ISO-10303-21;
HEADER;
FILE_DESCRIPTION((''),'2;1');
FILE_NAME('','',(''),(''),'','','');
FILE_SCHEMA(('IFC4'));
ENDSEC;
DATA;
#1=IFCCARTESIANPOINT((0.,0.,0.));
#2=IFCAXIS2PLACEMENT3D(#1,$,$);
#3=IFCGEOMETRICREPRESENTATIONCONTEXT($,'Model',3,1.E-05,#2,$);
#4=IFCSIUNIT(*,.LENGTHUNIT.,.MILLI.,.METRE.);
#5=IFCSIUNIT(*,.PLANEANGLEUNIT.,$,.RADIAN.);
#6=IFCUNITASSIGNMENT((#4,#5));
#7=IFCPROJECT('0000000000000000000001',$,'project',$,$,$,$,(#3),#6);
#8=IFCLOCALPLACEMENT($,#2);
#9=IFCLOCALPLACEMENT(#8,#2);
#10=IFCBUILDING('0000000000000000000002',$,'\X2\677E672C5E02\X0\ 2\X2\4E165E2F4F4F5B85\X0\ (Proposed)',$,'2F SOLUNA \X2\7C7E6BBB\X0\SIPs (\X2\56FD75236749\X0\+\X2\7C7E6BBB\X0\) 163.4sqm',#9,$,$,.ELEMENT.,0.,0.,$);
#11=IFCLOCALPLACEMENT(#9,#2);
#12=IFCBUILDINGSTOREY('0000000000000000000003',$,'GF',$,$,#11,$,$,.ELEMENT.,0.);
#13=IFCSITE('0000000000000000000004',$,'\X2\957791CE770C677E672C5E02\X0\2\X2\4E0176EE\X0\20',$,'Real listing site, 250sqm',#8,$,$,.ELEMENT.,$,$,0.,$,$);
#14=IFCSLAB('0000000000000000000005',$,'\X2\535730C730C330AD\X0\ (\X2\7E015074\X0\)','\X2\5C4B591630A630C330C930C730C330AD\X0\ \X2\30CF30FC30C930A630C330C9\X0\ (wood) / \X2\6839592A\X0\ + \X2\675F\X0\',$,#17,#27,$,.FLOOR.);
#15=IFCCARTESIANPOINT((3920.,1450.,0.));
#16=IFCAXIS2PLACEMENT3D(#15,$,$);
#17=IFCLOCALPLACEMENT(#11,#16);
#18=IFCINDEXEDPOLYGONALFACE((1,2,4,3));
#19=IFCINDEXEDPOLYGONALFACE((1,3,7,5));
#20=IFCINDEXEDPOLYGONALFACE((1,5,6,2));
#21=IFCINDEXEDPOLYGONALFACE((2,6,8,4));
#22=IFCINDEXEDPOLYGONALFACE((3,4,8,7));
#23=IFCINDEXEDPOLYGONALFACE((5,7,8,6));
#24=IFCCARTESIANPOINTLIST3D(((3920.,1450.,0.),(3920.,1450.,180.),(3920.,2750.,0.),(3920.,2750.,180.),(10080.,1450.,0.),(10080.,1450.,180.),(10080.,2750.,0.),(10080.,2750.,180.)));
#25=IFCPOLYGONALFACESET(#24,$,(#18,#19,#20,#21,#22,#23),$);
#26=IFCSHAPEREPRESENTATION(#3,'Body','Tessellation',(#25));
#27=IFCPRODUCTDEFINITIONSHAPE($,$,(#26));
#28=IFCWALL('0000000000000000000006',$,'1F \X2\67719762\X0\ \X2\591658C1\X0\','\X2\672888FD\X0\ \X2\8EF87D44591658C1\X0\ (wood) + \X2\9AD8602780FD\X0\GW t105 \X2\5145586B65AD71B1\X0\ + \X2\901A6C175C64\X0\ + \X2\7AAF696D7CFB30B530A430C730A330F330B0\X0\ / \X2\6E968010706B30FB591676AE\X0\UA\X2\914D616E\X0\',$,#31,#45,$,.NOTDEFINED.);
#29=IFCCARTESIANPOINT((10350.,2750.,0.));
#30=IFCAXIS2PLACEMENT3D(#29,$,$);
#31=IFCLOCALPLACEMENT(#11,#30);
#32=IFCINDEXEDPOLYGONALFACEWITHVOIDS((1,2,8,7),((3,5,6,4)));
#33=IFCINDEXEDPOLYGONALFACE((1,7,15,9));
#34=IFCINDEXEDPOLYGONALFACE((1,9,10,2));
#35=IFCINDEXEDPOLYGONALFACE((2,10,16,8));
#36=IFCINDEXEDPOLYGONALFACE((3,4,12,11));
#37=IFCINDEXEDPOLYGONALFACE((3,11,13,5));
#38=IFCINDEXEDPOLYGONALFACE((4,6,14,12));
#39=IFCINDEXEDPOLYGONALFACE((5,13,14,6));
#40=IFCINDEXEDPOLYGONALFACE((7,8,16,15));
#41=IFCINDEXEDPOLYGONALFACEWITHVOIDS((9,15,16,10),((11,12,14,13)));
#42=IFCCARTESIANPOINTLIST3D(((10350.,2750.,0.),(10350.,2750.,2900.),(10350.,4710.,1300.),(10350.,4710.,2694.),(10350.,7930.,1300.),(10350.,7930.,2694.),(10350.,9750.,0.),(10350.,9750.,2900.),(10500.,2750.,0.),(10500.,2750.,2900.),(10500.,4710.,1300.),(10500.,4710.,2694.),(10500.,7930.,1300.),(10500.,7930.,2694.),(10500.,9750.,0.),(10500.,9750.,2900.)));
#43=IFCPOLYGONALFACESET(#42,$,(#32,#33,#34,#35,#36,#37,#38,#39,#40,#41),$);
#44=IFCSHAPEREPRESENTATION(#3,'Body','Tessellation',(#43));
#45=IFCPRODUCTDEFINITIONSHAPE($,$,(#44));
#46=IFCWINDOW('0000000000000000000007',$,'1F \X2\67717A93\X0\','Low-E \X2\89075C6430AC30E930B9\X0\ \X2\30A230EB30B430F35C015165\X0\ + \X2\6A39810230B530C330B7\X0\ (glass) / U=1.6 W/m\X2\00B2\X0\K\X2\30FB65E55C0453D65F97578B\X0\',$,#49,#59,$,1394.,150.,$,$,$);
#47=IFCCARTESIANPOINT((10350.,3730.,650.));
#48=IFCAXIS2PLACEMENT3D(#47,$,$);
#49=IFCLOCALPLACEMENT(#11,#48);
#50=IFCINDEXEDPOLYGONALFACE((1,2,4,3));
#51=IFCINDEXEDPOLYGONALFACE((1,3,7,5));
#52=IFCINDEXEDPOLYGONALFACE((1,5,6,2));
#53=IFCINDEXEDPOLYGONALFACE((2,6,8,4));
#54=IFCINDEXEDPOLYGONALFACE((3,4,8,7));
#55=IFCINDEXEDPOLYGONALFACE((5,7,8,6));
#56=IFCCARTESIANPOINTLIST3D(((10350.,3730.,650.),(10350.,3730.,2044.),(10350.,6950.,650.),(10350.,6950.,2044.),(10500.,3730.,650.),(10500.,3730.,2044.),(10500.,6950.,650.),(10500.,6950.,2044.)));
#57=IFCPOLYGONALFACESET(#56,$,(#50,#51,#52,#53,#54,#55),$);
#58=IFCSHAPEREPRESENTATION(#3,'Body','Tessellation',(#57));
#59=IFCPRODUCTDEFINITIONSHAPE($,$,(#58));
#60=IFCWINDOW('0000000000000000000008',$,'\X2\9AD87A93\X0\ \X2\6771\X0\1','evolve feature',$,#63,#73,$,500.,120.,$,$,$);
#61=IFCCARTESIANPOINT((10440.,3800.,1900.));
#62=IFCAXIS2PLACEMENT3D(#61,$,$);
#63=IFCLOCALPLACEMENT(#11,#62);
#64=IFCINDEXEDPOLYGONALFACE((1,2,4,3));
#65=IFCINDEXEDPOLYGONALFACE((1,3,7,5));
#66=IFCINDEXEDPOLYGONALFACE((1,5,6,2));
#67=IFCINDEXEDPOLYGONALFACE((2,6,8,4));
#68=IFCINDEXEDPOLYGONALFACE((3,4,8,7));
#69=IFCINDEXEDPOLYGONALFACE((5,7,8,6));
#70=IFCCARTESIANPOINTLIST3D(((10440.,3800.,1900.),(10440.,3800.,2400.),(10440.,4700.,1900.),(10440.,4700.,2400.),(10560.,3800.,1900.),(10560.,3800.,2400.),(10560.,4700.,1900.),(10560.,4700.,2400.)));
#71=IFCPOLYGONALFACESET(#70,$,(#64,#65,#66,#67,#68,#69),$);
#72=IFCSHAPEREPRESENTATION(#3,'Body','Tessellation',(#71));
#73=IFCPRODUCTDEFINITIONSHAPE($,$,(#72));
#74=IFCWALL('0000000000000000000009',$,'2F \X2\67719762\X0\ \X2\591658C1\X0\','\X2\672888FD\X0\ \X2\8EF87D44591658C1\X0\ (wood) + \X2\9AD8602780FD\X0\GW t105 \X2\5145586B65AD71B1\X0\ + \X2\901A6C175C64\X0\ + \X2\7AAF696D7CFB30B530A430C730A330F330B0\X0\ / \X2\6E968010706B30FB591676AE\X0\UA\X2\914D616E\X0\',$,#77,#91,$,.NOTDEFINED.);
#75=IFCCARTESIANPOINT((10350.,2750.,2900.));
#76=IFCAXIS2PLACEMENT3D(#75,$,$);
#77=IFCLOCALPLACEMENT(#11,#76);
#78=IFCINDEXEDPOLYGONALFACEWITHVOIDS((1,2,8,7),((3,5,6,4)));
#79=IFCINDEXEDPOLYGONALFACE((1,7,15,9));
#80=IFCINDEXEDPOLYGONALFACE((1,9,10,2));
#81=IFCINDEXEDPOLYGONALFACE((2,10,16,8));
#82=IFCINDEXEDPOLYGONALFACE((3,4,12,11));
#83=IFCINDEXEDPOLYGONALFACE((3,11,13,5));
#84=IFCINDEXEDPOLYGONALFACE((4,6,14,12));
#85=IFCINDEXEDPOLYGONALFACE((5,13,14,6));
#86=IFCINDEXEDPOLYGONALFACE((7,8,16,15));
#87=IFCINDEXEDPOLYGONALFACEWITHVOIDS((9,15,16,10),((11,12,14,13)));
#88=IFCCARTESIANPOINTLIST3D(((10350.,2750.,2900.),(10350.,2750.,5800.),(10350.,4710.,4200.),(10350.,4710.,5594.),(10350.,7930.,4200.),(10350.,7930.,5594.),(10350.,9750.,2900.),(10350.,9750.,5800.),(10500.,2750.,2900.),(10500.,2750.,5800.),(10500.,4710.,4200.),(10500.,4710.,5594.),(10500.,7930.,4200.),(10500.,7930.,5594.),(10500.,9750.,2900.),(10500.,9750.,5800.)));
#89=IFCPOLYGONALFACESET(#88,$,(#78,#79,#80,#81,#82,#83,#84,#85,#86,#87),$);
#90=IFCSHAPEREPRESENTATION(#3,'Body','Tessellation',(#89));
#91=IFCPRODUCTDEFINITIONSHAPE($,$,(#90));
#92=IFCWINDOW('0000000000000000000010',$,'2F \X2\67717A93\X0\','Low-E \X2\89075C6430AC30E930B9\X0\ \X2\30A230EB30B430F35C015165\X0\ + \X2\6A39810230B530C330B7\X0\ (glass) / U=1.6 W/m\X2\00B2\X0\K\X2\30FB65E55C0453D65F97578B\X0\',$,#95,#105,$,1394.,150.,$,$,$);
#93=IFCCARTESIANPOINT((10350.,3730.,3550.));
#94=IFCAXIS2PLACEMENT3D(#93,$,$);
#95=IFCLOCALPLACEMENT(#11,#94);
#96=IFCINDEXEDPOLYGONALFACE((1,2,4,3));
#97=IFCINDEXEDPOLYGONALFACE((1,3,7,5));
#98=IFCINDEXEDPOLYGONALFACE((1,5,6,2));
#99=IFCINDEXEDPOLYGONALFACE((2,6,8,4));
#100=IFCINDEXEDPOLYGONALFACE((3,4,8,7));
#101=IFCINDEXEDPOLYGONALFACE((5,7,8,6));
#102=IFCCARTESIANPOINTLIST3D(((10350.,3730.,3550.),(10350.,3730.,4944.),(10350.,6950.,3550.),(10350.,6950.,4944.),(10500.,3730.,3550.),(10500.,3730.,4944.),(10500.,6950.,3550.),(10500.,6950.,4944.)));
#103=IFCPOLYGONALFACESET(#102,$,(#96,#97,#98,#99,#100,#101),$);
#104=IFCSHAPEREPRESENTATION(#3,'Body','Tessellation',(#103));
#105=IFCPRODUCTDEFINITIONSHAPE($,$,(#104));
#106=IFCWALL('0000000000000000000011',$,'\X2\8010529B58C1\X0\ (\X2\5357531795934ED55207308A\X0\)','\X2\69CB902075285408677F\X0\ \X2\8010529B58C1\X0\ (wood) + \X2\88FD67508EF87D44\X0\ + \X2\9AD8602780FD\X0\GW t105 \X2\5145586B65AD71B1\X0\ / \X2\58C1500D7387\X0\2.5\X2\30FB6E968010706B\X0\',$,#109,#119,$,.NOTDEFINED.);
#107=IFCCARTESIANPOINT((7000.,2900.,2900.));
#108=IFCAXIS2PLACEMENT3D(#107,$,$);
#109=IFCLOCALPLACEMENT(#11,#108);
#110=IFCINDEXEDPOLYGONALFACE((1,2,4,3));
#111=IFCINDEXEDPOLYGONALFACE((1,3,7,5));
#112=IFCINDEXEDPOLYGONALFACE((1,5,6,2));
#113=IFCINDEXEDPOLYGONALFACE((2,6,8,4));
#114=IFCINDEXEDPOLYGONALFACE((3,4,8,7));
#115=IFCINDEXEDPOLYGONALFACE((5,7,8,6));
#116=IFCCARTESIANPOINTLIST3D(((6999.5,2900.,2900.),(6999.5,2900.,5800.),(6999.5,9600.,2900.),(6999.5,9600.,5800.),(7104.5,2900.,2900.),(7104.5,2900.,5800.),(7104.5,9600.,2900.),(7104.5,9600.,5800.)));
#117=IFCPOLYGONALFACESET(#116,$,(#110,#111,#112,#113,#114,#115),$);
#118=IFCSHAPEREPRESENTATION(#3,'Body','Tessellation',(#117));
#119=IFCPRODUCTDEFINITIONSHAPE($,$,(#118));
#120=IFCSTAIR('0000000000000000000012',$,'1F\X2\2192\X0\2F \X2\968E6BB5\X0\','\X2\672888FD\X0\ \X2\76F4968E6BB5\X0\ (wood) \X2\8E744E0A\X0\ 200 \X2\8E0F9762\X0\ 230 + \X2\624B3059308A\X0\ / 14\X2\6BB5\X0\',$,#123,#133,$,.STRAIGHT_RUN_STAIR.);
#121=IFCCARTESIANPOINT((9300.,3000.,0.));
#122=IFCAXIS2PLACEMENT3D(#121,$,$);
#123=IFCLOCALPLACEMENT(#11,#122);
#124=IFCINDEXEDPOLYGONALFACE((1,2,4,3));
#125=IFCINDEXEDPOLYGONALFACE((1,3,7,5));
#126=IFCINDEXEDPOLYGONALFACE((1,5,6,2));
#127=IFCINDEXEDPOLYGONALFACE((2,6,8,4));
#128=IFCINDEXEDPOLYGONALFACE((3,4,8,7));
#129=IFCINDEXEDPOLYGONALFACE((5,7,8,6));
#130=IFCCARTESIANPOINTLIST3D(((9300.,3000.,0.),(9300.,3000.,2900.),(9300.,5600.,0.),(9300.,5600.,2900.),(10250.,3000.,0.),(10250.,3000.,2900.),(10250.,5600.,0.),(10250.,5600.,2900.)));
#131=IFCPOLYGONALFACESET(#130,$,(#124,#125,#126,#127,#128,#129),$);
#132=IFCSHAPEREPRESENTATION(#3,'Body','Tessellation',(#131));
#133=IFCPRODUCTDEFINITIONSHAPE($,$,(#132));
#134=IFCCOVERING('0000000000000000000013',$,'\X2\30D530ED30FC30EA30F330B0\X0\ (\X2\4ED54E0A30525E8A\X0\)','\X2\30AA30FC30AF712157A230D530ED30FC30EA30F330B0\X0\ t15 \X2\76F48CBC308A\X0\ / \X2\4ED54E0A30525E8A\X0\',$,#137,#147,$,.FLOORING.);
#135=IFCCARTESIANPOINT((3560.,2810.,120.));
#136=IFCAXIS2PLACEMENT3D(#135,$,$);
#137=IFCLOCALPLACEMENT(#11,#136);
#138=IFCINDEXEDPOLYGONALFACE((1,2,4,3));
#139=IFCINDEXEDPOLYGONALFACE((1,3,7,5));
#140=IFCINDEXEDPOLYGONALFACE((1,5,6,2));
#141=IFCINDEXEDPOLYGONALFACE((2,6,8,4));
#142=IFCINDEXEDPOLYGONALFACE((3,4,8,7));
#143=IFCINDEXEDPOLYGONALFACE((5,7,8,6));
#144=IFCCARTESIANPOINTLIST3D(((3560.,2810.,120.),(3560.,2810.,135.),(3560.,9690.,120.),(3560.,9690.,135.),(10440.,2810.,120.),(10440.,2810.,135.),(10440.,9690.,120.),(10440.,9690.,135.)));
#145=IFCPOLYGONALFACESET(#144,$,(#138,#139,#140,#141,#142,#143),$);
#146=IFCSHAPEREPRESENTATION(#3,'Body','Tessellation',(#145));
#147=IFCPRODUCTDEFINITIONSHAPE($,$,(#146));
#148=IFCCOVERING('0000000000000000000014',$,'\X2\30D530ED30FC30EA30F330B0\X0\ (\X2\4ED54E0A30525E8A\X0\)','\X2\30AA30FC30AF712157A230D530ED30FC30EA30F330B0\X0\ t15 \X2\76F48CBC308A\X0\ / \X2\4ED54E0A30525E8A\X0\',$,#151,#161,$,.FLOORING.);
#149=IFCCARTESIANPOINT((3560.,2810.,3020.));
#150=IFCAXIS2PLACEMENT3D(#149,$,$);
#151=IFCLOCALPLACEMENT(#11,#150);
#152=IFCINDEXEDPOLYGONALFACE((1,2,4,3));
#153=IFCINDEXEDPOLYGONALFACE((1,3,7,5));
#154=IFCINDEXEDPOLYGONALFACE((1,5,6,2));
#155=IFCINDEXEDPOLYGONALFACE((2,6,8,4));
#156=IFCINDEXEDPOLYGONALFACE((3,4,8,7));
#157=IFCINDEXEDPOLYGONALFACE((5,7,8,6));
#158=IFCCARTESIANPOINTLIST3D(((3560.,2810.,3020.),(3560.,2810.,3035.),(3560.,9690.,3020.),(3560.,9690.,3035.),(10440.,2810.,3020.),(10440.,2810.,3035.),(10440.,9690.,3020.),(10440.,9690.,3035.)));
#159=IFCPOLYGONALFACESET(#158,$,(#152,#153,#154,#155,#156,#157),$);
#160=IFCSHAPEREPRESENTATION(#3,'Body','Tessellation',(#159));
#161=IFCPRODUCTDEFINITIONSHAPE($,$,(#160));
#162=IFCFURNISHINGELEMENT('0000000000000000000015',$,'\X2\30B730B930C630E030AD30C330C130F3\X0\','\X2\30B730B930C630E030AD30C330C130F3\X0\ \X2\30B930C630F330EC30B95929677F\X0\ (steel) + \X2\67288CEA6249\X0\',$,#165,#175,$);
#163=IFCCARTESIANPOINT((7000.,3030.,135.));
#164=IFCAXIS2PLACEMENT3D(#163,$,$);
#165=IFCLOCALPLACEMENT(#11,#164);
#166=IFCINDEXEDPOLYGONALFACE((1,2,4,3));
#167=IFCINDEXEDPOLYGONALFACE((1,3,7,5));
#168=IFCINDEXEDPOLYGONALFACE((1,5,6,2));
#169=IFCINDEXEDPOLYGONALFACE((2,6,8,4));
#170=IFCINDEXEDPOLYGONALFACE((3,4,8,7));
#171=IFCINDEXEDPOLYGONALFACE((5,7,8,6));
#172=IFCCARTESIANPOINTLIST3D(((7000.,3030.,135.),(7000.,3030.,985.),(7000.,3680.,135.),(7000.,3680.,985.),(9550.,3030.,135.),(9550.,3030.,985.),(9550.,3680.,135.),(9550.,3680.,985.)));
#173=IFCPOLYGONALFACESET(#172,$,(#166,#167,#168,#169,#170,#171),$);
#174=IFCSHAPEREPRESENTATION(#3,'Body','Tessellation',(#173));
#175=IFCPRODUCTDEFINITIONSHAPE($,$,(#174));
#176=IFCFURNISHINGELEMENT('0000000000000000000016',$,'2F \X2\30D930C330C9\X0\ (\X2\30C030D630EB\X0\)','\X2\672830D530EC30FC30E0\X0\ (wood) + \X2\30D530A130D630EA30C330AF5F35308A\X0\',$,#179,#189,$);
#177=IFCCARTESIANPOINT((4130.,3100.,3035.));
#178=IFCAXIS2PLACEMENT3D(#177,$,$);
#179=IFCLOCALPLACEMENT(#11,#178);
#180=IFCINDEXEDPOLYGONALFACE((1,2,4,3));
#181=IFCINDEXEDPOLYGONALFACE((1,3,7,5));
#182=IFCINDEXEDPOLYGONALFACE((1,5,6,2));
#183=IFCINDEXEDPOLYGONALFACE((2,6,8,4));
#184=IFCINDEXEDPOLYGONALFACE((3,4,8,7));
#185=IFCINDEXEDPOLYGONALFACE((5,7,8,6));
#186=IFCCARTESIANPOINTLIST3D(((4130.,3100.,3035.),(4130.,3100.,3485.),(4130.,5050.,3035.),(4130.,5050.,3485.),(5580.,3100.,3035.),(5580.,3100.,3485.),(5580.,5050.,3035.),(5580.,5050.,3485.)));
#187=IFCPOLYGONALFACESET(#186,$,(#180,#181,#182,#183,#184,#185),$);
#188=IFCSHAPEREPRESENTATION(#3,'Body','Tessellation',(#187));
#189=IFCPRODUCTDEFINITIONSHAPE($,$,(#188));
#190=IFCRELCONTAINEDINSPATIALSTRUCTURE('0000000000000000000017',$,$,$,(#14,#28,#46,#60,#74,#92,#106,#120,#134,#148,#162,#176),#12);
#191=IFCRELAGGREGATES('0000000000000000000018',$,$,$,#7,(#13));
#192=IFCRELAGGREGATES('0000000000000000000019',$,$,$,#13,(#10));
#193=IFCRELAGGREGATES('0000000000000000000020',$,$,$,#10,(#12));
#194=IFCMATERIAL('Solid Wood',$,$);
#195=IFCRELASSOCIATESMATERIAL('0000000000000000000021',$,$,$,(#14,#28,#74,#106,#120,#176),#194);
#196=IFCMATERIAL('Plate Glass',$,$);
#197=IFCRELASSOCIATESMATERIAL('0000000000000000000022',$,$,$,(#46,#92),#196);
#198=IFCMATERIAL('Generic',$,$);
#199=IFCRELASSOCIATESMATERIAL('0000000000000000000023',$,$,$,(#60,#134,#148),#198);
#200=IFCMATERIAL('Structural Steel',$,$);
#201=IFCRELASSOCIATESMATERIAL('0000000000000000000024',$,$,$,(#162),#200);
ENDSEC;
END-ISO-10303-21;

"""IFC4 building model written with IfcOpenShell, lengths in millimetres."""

from ifc_helpers import new_model, si_unit, frame, frame_2d, origin, place, context, project, spatial, rectangle, extrude, material, element, fill, save


model = new_model("IFC4")

# Units and contexts
model_context = context("Model", 3, precision=1e-05, world=origin())
ifc_project = project(units=[si_unit("LENGTHUNIT", "METRE", prefix="MILLI"), si_unit("PLANEANGLEUNIT", "RADIAN")], contexts=[model_context])

# Site, building, storey
site_placement = place(None, origin())
site = spatial("IfcSite", under=ifc_project, at=site_placement, Name="長野県松本市2丁目20", ObjectType="Real listing site, 250sqm", CompositionType="ELEMENT", RefElevation=0.0)
building_placement = place(site_placement, origin())
building = spatial("IfcBuilding", under=site, at=building_placement, Name="松本市 2世帯住宅 (Proposed)", ObjectType="2F SOLUNA 籾殻SIPs (国産杉+籾殻) 163.4sqm", CompositionType="ELEMENT", ElevationOfRefHeight=0.0, ElevationOfTerrain=0.0)
storey_placement = place(building_placement, origin())
storey = spatial("IfcBuildingStorey", under=building, at=storey_placement, Name="GF", CompositionType="ELEMENT", Elevation=0.0)

# Slab
ifc_material_1 = material(Name="Solid Wood")
slab_placement = place(storey_placement, frame((3920.0, 1450.0, 0.0)))
element("IfcSlab", 1, at=slab_placement, inside=storey, material=ifc_material_1, Name="南デッキ (縁側)", Description="屋外ウッドデッキ ハードウッド (wood) / 根太 + 束", PredefinedType="FLOOR", context=model_context, shape_type="SweptSolid", body=[
    extrude(rectangle(XDim=6160.0, YDim=1300.0, at=frame_2d((3080.0, 650.0))), frame((3920.0, 1450.0, 0.0)), (0.0, 0.0, 1.0), 180.0),
])

# Wall, openings, windows
wall_1_placement = place(storey_placement, frame((10350.0, 2750.0, 0.0)))
wall_1 = element("IfcWall", 2, at=wall_1_placement, inside=storey, material=ifc_material_1, Name="1F 東面 外壁", Description="木製 軸組外壁 (wood) + 高性能GW t105 充填断熱 + 通気層 + 窯業系サイディング / 準耐火・外皮UA配慮", PredefinedType="NOTDEFINED", context=model_context, shape_type="SweptSolid", body=[
    extrude(rectangle(XDim=150.0, YDim=7000.0, at=frame_2d((75.0, 3500.0))), frame((10350.0, 2750.0, 0.0)), (0.0, 0.0, 1.0), 2900.0),
])
opening_1_placement = place(storey_placement, frame((10350.0, 3730.0, 650.0)))
opening_1 = element("IfcOpeningElement", 3, at=opening_1_placement, cuts=wall_1, PredefinedType="NOTDEFINED", context=model_context, shape_type="SweptSolid", body=[
    extrude(rectangle(XDim=150.0, YDim=3220.0, at=frame_2d((75.0, 1610.0))), frame((10350.0, 3730.0, 650.0)), (0.0, 0.0, 1.0), 1394.0),
])
opening_2_placement = place(storey_placement, frame((10440.0, 3800.0, 1900.0)))
opening_2 = element("IfcOpeningElement", 4, at=opening_2_placement, cuts=wall_1, PredefinedType="NOTDEFINED", context=model_context, shape_type="SweptSolid", body=[
    extrude(rectangle(XDim=120.0, YDim=900.0, at=frame_2d((60.0, 450.0))), frame((10440.0, 3800.0, 1900.0)), (0.0, 0.0, 1.0), 500.0),
])
ifc_material_2 = material(Name="Plate Glass")
window_1_placement = place(storey_placement, frame((10350.0, 3730.0, 650.0)))
window_1 = element("IfcWindow", 5, at=window_1_placement, inside=storey, material=ifc_material_2, Name="1F 東窓", Description="Low-E 複層ガラス アルゴン封入 + 樹脂サッシ (glass) / U=1.6 W/m²K・日射取得型", OverallHeight=1394.0, OverallWidth=150.0, context=model_context, shape_type="SweptSolid", body=[
    extrude(rectangle(XDim=150.0, YDim=3220.0, at=frame_2d((75.0, 1610.0))), frame((10350.0, 3730.0, 650.0)), (0.0, 0.0, 1.0), 1394.0),
])
fill(opening_1, window_1)
ifc_material_3 = material(Name="Generic")
window_2_placement = place(storey_placement, frame((10440.0, 3800.0, 1900.0)))
window_2 = element("IfcWindow", 6, at=window_2_placement, inside=storey, material=ifc_material_3, Name="高窓 東1", Description="evolve feature", OverallHeight=500.0, OverallWidth=120.0, context=model_context, shape_type="SweptSolid", body=[
    extrude(rectangle(XDim=120.0, YDim=900.0, at=frame_2d((60.0, 450.0))), frame((10440.0, 3800.0, 1900.0)), (0.0, 0.0, 1.0), 500.0),
])
fill(opening_2, window_2)

# Wall, opening, window
wall_2_placement = place(storey_placement, frame((10350.0, 2750.0, 2900.0)))
wall_2 = element("IfcWall", 7, at=wall_2_placement, inside=storey, material=ifc_material_1, Name="2F 東面 外壁", Description="木製 軸組外壁 (wood) + 高性能GW t105 充填断熱 + 通気層 + 窯業系サイディング / 準耐火・外皮UA配慮", PredefinedType="NOTDEFINED", context=model_context, shape_type="SweptSolid", body=[
    extrude(rectangle(XDim=150.0, YDim=7000.0, at=frame_2d((75.0, 3500.0))), frame((10350.0, 2750.0, 2900.0)), (0.0, 0.0, 1.0), 2900.0),
])
opening_3_placement = place(storey_placement, frame((10350.0, 3730.0, 3550.0)))
opening_3 = element("IfcOpeningElement", 8, at=opening_3_placement, cuts=wall_2, PredefinedType="NOTDEFINED", context=model_context, shape_type="SweptSolid", body=[
    extrude(rectangle(XDim=150.0, YDim=3220.0, at=frame_2d((75.0, 1610.0))), frame((10350.0, 3730.0, 3550.0)), (0.0, 0.0, 1.0), 1394.0),
])
window_3_placement = place(storey_placement, frame((10350.0, 3730.0, 3550.0)))
window_3 = element("IfcWindow", 9, at=window_3_placement, inside=storey, material=ifc_material_2, Name="2F 東窓", Description="Low-E 複層ガラス アルゴン封入 + 樹脂サッシ (glass) / U=1.6 W/m²K・日射取得型", OverallHeight=1394.0, OverallWidth=150.0, context=model_context, shape_type="SweptSolid", body=[
    extrude(rectangle(XDim=150.0, YDim=3220.0, at=frame_2d((75.0, 1610.0))), frame((10350.0, 3730.0, 3550.0)), (0.0, 0.0, 1.0), 1394.0),
])
fill(opening_3, window_3)

# Wall
wall_3_placement = place(storey_placement, frame((7000.0, 2900.0, 2900.0)))
element("IfcWall", 10, at=wall_3_placement, inside=storey, material=ifc_material_1, Name="耐力壁 (南北間仕切り)", Description="構造用合板 耐力壁 (wood) + 製材軸組 + 高性能GW t105 充填断熱 / 壁倍率2.5・準耐火", PredefinedType="NOTDEFINED", context=model_context, shape_type="SweptSolid", body=[
    extrude(rectangle(XDim=105.0, YDim=6700.0, at=frame_2d((52.0, 3350.0))), frame((7000.0, 2900.0, 2900.0)), (0.0, 0.0, 1.0), 2900.0),
])

# Stair
stair_placement = place(storey_placement, frame((9300.0, 3000.0, 0.0)))
element("IfcStair", 11, at=stair_placement, inside=storey, material=ifc_material_1, Name="1F→2F 階段", Description="木製 直階段 (wood) 蹴上 200 踏面 230 + 手すり / 14段", PredefinedType="STRAIGHT_RUN_STAIR", context=model_context, shape_type="SweptSolid", body=[
    extrude(rectangle(XDim=950.0, YDim=2600.0, at=frame_2d((475.0, 1300.0))), frame((9300.0, 3000.0, 0.0)), (0.0, 0.0, 1.0), 2900.0),
])

# Coverings
covering_1_placement = place(storey_placement, frame((3560.0, 2810.0, 120.0)))
element("IfcCovering", 12, at=covering_1_placement, inside=storey, material=ifc_material_3, Name="フローリング (仕上げ床)", Description="オーク無垢フローリング t15 直貼り / 仕上げ床", PredefinedType="FLOORING", context=model_context, shape_type="SweptSolid", body=[
    extrude(rectangle(XDim=6880.0, YDim=6880.0, at=frame_2d((3440.0, 3440.0))), frame((3560.0, 2810.0, 120.0)), (0.0, 0.0, 1.0), 15.0),
])
covering_2_placement = place(storey_placement, frame((3560.0, 2810.0, 3020.0)))
element("IfcCovering", 13, at=covering_2_placement, inside=storey, material=ifc_material_3, Name="フローリング (仕上げ床)", Description="オーク無垢フローリング t15 直貼り / 仕上げ床", PredefinedType="FLOORING", context=model_context, shape_type="SweptSolid", body=[
    extrude(rectangle(XDim=6880.0, YDim=6880.0, at=frame_2d((3440.0, 3440.0))), frame((3560.0, 2810.0, 3020.0)), (0.0, 0.0, 1.0), 15.0),
])

# Furnishing elements
ifc_material_4 = material(Name="Structural Steel")
furnishing_1_placement = place(storey_placement, frame((7000.0, 3030.0, 135.0)))
element("IfcFurnishingElement", 14, at=furnishing_1_placement, inside=storey, material=ifc_material_4, Name="システムキッチン", Description="システムキッチン ステンレス天板 (steel) + 木質扉", context=model_context, shape_type="SweptSolid", body=[
    extrude(rectangle(XDim=2550.0, YDim=650.0, at=frame_2d((1275.0, 325.0))), frame((7000.0, 3030.0, 135.0)), (0.0, 0.0, 1.0), 850.0),
])
furnishing_2_placement = place(storey_placement, frame((4130.0, 3100.0, 3035.0)))
element("IfcFurnishingElement", 15, at=furnishing_2_placement, inside=storey, material=ifc_material_1, Name="2F ベッド (ダブル)", Description="木フレーム (wood) + ファブリック張り", context=model_context, shape_type="SweptSolid", body=[
    extrude(rectangle(XDim=1450.0, YDim=1950.0, at=frame_2d((725.0, 975.0))), frame((4130.0, 3100.0, 3035.0)), (0.0, 0.0, 1.0), 450.0),
])

save(model, "model.ifc")
